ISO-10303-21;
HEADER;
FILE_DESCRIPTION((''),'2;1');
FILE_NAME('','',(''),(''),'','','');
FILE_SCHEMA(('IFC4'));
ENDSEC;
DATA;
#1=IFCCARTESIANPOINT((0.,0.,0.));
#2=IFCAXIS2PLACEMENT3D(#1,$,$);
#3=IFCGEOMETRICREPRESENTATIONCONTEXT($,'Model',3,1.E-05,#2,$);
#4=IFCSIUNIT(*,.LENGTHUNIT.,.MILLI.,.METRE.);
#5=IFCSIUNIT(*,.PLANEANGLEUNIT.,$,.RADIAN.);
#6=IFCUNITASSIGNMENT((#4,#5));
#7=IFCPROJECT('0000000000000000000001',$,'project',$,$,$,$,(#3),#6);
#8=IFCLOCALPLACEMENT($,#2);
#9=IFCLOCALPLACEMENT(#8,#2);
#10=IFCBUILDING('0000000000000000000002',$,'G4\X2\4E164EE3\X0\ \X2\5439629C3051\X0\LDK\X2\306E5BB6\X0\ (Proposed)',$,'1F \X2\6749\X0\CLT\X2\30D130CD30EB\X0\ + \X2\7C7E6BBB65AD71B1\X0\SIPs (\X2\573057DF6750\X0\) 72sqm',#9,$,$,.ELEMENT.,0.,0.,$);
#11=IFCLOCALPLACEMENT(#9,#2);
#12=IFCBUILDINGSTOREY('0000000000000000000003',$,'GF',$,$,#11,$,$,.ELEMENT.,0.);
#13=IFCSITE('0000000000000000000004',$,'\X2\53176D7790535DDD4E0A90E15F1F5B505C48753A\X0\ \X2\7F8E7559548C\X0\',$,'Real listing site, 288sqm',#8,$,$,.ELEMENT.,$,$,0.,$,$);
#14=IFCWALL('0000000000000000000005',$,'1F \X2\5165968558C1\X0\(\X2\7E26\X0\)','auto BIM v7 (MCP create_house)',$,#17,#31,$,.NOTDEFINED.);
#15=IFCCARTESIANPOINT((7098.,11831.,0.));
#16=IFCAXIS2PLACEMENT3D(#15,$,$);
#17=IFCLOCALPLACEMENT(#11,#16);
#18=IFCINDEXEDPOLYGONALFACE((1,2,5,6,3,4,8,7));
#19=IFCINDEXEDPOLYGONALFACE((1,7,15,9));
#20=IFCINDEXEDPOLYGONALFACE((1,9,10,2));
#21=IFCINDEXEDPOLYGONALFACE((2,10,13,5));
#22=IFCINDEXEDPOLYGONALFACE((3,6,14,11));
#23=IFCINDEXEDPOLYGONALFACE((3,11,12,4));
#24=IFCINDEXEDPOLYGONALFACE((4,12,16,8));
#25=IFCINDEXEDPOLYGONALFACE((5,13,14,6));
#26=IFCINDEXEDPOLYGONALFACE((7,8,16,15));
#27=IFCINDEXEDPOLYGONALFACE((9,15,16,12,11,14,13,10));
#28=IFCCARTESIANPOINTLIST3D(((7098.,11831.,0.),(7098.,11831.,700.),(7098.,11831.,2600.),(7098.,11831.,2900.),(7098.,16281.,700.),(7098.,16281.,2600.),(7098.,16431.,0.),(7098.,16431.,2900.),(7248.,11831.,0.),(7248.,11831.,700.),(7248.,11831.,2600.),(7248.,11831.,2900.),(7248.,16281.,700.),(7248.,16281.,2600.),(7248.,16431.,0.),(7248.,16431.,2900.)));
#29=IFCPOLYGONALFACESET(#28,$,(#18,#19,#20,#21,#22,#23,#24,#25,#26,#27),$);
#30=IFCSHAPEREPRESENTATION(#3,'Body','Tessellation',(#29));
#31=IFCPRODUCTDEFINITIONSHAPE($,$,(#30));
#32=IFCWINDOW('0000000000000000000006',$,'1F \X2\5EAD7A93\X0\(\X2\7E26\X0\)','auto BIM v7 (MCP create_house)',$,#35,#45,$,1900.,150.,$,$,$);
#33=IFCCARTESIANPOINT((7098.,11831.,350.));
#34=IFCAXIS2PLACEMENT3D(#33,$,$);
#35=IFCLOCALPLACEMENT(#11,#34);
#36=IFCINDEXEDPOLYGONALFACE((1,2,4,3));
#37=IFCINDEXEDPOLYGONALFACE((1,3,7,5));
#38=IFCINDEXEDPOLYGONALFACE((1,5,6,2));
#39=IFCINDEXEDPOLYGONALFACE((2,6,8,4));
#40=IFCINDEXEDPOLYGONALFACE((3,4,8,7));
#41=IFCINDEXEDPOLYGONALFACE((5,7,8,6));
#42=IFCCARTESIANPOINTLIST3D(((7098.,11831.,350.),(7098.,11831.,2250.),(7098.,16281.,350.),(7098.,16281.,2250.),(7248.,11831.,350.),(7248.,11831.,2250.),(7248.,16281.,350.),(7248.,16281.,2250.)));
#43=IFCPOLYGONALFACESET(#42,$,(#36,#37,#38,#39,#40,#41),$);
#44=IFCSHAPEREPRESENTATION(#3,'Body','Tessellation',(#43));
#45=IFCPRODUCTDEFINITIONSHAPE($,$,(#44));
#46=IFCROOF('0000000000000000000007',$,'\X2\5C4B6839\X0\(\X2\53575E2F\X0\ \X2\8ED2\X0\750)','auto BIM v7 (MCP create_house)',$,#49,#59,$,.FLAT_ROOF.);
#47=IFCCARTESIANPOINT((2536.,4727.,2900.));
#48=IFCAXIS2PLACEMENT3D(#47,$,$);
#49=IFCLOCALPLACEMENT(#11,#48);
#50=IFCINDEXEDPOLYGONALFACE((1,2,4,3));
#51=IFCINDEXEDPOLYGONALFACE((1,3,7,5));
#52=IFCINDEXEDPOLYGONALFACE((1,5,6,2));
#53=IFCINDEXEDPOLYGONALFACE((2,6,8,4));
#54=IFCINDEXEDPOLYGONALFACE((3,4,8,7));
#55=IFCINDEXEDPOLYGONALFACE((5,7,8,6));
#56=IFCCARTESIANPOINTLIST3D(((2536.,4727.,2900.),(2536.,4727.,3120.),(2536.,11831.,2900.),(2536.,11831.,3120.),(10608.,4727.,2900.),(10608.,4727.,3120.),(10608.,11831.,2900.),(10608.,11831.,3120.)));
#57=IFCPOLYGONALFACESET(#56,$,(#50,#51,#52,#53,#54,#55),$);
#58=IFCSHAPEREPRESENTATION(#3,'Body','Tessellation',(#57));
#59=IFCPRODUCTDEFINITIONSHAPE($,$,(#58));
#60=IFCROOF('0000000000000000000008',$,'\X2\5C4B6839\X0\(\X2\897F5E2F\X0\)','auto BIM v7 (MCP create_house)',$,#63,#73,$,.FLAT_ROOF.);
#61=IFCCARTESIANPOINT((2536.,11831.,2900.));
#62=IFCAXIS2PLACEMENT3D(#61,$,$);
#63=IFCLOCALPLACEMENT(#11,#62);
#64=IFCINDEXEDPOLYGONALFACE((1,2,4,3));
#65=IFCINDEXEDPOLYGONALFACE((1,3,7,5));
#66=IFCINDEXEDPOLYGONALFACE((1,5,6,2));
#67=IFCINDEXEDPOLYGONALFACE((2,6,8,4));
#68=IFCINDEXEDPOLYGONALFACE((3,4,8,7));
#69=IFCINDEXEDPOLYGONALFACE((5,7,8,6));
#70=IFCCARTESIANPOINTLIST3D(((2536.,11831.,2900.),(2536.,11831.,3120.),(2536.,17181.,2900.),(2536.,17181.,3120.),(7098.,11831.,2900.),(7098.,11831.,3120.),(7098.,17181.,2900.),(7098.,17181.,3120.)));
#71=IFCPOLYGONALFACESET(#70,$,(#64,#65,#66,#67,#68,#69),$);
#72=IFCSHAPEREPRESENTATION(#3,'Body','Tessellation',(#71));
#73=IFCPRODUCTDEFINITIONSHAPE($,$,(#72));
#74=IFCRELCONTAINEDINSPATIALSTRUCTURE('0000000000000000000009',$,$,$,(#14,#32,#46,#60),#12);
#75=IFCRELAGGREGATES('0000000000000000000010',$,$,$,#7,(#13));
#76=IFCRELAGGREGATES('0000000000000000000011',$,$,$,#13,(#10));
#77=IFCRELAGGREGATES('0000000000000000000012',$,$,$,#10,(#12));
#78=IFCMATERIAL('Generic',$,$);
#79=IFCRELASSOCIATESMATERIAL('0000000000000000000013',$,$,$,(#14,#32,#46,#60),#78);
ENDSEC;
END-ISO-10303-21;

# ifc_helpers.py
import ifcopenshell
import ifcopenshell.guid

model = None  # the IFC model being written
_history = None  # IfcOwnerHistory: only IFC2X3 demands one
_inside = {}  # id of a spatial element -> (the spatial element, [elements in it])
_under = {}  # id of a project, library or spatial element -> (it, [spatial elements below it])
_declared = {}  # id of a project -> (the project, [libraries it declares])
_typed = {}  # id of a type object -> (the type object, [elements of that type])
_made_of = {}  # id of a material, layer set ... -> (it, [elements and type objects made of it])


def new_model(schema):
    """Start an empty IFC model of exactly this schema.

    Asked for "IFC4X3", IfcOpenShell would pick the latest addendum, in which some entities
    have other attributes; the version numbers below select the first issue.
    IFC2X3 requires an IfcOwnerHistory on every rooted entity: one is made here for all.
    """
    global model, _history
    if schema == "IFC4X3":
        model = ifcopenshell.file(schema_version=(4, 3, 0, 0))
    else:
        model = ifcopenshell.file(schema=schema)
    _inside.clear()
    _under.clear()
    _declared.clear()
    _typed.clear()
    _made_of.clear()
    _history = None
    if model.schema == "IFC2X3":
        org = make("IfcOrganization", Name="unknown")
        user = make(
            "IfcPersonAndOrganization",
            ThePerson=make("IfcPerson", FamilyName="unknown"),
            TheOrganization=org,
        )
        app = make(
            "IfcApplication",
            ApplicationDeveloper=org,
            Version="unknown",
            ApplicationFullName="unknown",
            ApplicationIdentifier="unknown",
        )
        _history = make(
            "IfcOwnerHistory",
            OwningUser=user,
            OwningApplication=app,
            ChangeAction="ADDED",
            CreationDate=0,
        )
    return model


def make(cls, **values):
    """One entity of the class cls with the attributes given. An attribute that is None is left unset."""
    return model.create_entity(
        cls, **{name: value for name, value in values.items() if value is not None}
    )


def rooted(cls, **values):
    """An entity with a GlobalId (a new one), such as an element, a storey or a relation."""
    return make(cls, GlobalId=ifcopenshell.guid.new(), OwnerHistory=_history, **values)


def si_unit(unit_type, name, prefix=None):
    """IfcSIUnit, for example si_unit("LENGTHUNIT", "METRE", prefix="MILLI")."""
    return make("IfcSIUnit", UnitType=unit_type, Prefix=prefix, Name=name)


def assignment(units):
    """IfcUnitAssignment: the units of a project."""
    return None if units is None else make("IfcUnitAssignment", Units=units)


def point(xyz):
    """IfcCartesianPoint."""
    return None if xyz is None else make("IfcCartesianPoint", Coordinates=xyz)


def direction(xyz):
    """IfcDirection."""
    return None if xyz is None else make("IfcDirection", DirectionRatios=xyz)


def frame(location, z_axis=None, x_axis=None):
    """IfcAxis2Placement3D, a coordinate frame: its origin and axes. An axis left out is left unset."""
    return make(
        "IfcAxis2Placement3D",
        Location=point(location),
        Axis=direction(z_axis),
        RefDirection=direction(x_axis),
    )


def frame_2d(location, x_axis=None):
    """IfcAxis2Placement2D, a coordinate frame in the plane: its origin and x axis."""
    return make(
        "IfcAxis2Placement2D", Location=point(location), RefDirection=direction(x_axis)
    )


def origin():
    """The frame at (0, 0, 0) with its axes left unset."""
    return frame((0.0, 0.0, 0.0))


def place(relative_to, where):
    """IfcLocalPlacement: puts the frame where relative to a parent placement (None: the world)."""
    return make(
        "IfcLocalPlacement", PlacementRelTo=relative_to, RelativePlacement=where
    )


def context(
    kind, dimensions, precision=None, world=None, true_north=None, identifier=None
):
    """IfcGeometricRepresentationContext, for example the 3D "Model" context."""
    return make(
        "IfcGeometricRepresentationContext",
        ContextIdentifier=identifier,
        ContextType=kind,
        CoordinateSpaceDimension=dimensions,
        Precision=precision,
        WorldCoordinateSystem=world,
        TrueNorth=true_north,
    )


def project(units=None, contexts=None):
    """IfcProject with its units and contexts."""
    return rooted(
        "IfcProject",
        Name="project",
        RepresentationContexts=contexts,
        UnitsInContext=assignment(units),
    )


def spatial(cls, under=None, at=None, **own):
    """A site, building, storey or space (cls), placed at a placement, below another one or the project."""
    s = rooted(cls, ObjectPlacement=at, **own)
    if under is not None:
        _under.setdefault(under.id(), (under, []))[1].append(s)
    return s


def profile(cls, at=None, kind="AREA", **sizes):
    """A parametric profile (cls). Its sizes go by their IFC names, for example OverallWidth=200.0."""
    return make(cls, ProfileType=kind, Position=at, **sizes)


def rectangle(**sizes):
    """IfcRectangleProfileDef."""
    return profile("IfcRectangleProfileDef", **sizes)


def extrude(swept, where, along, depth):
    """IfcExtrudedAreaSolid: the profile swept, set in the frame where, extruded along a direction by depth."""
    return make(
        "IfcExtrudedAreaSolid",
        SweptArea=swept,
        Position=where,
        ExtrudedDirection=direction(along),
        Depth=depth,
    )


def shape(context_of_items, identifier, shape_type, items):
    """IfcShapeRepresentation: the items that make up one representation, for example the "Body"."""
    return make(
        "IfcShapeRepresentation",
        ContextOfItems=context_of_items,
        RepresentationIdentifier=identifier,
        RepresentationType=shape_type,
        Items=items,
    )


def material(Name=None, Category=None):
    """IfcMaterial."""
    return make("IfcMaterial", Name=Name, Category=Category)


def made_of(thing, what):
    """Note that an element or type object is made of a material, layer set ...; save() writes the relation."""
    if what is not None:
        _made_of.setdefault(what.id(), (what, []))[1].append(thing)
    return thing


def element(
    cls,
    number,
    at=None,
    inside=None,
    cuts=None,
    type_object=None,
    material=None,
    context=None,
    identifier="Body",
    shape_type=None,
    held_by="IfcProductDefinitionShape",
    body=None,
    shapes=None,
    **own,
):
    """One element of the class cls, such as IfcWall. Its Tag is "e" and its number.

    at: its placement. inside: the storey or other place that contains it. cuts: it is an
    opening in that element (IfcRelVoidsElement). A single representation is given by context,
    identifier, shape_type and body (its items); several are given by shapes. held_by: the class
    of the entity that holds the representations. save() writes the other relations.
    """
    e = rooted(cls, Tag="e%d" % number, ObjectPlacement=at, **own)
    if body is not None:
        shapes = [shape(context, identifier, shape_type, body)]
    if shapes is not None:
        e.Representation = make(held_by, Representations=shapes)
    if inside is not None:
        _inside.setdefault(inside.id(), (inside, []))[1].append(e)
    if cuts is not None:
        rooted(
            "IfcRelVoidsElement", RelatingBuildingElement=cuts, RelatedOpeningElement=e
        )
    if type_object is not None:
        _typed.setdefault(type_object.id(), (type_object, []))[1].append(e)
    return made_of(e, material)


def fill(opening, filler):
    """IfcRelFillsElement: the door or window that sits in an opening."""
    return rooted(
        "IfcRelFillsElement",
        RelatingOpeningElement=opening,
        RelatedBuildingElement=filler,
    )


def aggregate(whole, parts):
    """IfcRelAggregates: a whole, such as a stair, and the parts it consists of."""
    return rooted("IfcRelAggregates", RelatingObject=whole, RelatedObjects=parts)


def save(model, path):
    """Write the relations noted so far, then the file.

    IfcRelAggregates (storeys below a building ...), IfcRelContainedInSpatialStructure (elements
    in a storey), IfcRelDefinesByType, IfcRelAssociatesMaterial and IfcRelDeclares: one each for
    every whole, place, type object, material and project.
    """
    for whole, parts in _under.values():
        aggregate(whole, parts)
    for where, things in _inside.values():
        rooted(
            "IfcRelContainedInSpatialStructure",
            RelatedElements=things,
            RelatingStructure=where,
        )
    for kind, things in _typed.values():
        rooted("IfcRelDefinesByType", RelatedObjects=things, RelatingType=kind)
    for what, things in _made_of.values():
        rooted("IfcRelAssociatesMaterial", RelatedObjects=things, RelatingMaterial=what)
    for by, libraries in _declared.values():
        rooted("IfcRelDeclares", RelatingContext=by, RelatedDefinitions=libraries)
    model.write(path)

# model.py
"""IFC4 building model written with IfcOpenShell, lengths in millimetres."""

from ifc_helpers import new_model, si_unit, frame, frame_2d, origin, place, context, project, spatial, rectangle, extrude, material, element, fill, save


model = new_model("IFC4")

# Units and contexts
model_context = context("Model", 3, precision=1e-05, world=origin())
ifc_project = project(units=[si_unit("LENGTHUNIT", "METRE", prefix="MILLI"), si_unit("PLANEANGLEUNIT", "RADIAN")], contexts=[model_context])

# Site, building, storey
site_placement = place(None, origin())
site = spatial("IfcSite", under=ifc_project, at=site_placement, Name="北海道川上郡弟子屈町 美留和", ObjectType="Real listing site, 288sqm", CompositionType="ELEMENT", RefElevation=0.0)
building_placement = place(site_placement, origin())
building = spatial("IfcBuilding", under=site, at=building_placement, Name="G4世代 吹抜けLDKの家 (Proposed)", ObjectType="1F 杉CLTパネル + 籾殻断熱SIPs (地域材) 72sqm", CompositionType="ELEMENT", ElevationOfRefHeight=0.0, ElevationOfTerrain=0.0)
storey_placement = place(building_placement, origin())
storey = spatial("IfcBuildingStorey", under=building, at=storey_placement, Name="GF", CompositionType="ELEMENT", Elevation=0.0)

# Shared definitions
ifc_material = material(Name="Generic")

# Wall, opening, window
wall_1_placement = place(storey_placement, frame((7098.0, 11831.0, 0.0)))
wall_1 = element("IfcWall", 1, at=wall_1_placement, inside=storey, material=ifc_material, Name="1F 入隅壁(縦)", Description="auto BIM v7 (MCP create_house)", PredefinedType="NOTDEFINED", context=model_context, shape_type="SweptSolid", body=[
    extrude(rectangle(XDim=150.0, YDim=4600.0, at=frame_2d((75.0, 2300.0))), frame((7098.0, 11831.0, 0.0)), (0.0, 0.0, 1.0), 2900.0),
])
opening_1_placement = place(storey_placement, frame((7098.0, 11831.0, 350.0)))
opening_1 = element("IfcOpeningElement", 2, at=opening_1_placement, cuts=wall_1, PredefinedType="NOTDEFINED", context=model_context, shape_type="SweptSolid", body=[
    extrude(rectangle(XDim=150.0, YDim=4450.0, at=frame_2d((75.0, 2225.0))), frame((7098.0, 11831.0, 350.0)), (0.0, 0.0, 1.0), 1900.0),
])
window_1_placement = place(storey_placement, frame((7098.0, 11831.0, 350.0)))
window_1 = element("IfcWindow", 3, at=window_1_placement, inside=storey, material=ifc_material, Name="1F 庭窓(縦)", Description="auto BIM v7 (MCP create_house)", OverallHeight=1900.0, OverallWidth=150.0, context=model_context, shape_type="SweptSolid", body=[
    extrude(rectangle(XDim=150.0, YDim=4450.0, at=frame_2d((75.0, 2225.0))), frame((7098.0, 11831.0, 350.0)), (0.0, 0.0, 1.0), 1900.0),
])
fill(opening_1, window_1)

# Roofs
roof_1_placement = place(storey_placement, frame((2536.0, 4727.0, 2900.0)))
element("IfcRoof", 4, at=roof_1_placement, inside=storey, material=ifc_material, Name="屋根(南帯 軒750)", Description="auto BIM v7 (MCP create_house)", PredefinedType="FLAT_ROOF", context=model_context, shape_type="SweptSolid", body=[
    extrude(rectangle(XDim=8072.0, YDim=7104.0, at=frame_2d((4036.0, 3552.0))), frame((2536.0, 4727.0, 2900.0)), (0.0, 0.0, 1.0), 220.0),
])
roof_2_placement = place(storey_placement, frame((2536.0, 11831.0, 2900.0)))
element("IfcRoof", 5, at=roof_2_placement, inside=storey, material=ifc_material, Name="屋根(西帯)", Description="auto BIM v7 (MCP create_house)", PredefinedType="FLAT_ROOF", context=model_context, shape_type="SweptSolid", body=[
    extrude(rectangle(XDim=4562.0, YDim=5350.0, at=frame_2d((2281.0, 2675.0))), frame((2536.0, 11831.0, 2900.0)), (0.0, 0.0, 1.0), 220.0),
])

save(model, "model.ifc")
